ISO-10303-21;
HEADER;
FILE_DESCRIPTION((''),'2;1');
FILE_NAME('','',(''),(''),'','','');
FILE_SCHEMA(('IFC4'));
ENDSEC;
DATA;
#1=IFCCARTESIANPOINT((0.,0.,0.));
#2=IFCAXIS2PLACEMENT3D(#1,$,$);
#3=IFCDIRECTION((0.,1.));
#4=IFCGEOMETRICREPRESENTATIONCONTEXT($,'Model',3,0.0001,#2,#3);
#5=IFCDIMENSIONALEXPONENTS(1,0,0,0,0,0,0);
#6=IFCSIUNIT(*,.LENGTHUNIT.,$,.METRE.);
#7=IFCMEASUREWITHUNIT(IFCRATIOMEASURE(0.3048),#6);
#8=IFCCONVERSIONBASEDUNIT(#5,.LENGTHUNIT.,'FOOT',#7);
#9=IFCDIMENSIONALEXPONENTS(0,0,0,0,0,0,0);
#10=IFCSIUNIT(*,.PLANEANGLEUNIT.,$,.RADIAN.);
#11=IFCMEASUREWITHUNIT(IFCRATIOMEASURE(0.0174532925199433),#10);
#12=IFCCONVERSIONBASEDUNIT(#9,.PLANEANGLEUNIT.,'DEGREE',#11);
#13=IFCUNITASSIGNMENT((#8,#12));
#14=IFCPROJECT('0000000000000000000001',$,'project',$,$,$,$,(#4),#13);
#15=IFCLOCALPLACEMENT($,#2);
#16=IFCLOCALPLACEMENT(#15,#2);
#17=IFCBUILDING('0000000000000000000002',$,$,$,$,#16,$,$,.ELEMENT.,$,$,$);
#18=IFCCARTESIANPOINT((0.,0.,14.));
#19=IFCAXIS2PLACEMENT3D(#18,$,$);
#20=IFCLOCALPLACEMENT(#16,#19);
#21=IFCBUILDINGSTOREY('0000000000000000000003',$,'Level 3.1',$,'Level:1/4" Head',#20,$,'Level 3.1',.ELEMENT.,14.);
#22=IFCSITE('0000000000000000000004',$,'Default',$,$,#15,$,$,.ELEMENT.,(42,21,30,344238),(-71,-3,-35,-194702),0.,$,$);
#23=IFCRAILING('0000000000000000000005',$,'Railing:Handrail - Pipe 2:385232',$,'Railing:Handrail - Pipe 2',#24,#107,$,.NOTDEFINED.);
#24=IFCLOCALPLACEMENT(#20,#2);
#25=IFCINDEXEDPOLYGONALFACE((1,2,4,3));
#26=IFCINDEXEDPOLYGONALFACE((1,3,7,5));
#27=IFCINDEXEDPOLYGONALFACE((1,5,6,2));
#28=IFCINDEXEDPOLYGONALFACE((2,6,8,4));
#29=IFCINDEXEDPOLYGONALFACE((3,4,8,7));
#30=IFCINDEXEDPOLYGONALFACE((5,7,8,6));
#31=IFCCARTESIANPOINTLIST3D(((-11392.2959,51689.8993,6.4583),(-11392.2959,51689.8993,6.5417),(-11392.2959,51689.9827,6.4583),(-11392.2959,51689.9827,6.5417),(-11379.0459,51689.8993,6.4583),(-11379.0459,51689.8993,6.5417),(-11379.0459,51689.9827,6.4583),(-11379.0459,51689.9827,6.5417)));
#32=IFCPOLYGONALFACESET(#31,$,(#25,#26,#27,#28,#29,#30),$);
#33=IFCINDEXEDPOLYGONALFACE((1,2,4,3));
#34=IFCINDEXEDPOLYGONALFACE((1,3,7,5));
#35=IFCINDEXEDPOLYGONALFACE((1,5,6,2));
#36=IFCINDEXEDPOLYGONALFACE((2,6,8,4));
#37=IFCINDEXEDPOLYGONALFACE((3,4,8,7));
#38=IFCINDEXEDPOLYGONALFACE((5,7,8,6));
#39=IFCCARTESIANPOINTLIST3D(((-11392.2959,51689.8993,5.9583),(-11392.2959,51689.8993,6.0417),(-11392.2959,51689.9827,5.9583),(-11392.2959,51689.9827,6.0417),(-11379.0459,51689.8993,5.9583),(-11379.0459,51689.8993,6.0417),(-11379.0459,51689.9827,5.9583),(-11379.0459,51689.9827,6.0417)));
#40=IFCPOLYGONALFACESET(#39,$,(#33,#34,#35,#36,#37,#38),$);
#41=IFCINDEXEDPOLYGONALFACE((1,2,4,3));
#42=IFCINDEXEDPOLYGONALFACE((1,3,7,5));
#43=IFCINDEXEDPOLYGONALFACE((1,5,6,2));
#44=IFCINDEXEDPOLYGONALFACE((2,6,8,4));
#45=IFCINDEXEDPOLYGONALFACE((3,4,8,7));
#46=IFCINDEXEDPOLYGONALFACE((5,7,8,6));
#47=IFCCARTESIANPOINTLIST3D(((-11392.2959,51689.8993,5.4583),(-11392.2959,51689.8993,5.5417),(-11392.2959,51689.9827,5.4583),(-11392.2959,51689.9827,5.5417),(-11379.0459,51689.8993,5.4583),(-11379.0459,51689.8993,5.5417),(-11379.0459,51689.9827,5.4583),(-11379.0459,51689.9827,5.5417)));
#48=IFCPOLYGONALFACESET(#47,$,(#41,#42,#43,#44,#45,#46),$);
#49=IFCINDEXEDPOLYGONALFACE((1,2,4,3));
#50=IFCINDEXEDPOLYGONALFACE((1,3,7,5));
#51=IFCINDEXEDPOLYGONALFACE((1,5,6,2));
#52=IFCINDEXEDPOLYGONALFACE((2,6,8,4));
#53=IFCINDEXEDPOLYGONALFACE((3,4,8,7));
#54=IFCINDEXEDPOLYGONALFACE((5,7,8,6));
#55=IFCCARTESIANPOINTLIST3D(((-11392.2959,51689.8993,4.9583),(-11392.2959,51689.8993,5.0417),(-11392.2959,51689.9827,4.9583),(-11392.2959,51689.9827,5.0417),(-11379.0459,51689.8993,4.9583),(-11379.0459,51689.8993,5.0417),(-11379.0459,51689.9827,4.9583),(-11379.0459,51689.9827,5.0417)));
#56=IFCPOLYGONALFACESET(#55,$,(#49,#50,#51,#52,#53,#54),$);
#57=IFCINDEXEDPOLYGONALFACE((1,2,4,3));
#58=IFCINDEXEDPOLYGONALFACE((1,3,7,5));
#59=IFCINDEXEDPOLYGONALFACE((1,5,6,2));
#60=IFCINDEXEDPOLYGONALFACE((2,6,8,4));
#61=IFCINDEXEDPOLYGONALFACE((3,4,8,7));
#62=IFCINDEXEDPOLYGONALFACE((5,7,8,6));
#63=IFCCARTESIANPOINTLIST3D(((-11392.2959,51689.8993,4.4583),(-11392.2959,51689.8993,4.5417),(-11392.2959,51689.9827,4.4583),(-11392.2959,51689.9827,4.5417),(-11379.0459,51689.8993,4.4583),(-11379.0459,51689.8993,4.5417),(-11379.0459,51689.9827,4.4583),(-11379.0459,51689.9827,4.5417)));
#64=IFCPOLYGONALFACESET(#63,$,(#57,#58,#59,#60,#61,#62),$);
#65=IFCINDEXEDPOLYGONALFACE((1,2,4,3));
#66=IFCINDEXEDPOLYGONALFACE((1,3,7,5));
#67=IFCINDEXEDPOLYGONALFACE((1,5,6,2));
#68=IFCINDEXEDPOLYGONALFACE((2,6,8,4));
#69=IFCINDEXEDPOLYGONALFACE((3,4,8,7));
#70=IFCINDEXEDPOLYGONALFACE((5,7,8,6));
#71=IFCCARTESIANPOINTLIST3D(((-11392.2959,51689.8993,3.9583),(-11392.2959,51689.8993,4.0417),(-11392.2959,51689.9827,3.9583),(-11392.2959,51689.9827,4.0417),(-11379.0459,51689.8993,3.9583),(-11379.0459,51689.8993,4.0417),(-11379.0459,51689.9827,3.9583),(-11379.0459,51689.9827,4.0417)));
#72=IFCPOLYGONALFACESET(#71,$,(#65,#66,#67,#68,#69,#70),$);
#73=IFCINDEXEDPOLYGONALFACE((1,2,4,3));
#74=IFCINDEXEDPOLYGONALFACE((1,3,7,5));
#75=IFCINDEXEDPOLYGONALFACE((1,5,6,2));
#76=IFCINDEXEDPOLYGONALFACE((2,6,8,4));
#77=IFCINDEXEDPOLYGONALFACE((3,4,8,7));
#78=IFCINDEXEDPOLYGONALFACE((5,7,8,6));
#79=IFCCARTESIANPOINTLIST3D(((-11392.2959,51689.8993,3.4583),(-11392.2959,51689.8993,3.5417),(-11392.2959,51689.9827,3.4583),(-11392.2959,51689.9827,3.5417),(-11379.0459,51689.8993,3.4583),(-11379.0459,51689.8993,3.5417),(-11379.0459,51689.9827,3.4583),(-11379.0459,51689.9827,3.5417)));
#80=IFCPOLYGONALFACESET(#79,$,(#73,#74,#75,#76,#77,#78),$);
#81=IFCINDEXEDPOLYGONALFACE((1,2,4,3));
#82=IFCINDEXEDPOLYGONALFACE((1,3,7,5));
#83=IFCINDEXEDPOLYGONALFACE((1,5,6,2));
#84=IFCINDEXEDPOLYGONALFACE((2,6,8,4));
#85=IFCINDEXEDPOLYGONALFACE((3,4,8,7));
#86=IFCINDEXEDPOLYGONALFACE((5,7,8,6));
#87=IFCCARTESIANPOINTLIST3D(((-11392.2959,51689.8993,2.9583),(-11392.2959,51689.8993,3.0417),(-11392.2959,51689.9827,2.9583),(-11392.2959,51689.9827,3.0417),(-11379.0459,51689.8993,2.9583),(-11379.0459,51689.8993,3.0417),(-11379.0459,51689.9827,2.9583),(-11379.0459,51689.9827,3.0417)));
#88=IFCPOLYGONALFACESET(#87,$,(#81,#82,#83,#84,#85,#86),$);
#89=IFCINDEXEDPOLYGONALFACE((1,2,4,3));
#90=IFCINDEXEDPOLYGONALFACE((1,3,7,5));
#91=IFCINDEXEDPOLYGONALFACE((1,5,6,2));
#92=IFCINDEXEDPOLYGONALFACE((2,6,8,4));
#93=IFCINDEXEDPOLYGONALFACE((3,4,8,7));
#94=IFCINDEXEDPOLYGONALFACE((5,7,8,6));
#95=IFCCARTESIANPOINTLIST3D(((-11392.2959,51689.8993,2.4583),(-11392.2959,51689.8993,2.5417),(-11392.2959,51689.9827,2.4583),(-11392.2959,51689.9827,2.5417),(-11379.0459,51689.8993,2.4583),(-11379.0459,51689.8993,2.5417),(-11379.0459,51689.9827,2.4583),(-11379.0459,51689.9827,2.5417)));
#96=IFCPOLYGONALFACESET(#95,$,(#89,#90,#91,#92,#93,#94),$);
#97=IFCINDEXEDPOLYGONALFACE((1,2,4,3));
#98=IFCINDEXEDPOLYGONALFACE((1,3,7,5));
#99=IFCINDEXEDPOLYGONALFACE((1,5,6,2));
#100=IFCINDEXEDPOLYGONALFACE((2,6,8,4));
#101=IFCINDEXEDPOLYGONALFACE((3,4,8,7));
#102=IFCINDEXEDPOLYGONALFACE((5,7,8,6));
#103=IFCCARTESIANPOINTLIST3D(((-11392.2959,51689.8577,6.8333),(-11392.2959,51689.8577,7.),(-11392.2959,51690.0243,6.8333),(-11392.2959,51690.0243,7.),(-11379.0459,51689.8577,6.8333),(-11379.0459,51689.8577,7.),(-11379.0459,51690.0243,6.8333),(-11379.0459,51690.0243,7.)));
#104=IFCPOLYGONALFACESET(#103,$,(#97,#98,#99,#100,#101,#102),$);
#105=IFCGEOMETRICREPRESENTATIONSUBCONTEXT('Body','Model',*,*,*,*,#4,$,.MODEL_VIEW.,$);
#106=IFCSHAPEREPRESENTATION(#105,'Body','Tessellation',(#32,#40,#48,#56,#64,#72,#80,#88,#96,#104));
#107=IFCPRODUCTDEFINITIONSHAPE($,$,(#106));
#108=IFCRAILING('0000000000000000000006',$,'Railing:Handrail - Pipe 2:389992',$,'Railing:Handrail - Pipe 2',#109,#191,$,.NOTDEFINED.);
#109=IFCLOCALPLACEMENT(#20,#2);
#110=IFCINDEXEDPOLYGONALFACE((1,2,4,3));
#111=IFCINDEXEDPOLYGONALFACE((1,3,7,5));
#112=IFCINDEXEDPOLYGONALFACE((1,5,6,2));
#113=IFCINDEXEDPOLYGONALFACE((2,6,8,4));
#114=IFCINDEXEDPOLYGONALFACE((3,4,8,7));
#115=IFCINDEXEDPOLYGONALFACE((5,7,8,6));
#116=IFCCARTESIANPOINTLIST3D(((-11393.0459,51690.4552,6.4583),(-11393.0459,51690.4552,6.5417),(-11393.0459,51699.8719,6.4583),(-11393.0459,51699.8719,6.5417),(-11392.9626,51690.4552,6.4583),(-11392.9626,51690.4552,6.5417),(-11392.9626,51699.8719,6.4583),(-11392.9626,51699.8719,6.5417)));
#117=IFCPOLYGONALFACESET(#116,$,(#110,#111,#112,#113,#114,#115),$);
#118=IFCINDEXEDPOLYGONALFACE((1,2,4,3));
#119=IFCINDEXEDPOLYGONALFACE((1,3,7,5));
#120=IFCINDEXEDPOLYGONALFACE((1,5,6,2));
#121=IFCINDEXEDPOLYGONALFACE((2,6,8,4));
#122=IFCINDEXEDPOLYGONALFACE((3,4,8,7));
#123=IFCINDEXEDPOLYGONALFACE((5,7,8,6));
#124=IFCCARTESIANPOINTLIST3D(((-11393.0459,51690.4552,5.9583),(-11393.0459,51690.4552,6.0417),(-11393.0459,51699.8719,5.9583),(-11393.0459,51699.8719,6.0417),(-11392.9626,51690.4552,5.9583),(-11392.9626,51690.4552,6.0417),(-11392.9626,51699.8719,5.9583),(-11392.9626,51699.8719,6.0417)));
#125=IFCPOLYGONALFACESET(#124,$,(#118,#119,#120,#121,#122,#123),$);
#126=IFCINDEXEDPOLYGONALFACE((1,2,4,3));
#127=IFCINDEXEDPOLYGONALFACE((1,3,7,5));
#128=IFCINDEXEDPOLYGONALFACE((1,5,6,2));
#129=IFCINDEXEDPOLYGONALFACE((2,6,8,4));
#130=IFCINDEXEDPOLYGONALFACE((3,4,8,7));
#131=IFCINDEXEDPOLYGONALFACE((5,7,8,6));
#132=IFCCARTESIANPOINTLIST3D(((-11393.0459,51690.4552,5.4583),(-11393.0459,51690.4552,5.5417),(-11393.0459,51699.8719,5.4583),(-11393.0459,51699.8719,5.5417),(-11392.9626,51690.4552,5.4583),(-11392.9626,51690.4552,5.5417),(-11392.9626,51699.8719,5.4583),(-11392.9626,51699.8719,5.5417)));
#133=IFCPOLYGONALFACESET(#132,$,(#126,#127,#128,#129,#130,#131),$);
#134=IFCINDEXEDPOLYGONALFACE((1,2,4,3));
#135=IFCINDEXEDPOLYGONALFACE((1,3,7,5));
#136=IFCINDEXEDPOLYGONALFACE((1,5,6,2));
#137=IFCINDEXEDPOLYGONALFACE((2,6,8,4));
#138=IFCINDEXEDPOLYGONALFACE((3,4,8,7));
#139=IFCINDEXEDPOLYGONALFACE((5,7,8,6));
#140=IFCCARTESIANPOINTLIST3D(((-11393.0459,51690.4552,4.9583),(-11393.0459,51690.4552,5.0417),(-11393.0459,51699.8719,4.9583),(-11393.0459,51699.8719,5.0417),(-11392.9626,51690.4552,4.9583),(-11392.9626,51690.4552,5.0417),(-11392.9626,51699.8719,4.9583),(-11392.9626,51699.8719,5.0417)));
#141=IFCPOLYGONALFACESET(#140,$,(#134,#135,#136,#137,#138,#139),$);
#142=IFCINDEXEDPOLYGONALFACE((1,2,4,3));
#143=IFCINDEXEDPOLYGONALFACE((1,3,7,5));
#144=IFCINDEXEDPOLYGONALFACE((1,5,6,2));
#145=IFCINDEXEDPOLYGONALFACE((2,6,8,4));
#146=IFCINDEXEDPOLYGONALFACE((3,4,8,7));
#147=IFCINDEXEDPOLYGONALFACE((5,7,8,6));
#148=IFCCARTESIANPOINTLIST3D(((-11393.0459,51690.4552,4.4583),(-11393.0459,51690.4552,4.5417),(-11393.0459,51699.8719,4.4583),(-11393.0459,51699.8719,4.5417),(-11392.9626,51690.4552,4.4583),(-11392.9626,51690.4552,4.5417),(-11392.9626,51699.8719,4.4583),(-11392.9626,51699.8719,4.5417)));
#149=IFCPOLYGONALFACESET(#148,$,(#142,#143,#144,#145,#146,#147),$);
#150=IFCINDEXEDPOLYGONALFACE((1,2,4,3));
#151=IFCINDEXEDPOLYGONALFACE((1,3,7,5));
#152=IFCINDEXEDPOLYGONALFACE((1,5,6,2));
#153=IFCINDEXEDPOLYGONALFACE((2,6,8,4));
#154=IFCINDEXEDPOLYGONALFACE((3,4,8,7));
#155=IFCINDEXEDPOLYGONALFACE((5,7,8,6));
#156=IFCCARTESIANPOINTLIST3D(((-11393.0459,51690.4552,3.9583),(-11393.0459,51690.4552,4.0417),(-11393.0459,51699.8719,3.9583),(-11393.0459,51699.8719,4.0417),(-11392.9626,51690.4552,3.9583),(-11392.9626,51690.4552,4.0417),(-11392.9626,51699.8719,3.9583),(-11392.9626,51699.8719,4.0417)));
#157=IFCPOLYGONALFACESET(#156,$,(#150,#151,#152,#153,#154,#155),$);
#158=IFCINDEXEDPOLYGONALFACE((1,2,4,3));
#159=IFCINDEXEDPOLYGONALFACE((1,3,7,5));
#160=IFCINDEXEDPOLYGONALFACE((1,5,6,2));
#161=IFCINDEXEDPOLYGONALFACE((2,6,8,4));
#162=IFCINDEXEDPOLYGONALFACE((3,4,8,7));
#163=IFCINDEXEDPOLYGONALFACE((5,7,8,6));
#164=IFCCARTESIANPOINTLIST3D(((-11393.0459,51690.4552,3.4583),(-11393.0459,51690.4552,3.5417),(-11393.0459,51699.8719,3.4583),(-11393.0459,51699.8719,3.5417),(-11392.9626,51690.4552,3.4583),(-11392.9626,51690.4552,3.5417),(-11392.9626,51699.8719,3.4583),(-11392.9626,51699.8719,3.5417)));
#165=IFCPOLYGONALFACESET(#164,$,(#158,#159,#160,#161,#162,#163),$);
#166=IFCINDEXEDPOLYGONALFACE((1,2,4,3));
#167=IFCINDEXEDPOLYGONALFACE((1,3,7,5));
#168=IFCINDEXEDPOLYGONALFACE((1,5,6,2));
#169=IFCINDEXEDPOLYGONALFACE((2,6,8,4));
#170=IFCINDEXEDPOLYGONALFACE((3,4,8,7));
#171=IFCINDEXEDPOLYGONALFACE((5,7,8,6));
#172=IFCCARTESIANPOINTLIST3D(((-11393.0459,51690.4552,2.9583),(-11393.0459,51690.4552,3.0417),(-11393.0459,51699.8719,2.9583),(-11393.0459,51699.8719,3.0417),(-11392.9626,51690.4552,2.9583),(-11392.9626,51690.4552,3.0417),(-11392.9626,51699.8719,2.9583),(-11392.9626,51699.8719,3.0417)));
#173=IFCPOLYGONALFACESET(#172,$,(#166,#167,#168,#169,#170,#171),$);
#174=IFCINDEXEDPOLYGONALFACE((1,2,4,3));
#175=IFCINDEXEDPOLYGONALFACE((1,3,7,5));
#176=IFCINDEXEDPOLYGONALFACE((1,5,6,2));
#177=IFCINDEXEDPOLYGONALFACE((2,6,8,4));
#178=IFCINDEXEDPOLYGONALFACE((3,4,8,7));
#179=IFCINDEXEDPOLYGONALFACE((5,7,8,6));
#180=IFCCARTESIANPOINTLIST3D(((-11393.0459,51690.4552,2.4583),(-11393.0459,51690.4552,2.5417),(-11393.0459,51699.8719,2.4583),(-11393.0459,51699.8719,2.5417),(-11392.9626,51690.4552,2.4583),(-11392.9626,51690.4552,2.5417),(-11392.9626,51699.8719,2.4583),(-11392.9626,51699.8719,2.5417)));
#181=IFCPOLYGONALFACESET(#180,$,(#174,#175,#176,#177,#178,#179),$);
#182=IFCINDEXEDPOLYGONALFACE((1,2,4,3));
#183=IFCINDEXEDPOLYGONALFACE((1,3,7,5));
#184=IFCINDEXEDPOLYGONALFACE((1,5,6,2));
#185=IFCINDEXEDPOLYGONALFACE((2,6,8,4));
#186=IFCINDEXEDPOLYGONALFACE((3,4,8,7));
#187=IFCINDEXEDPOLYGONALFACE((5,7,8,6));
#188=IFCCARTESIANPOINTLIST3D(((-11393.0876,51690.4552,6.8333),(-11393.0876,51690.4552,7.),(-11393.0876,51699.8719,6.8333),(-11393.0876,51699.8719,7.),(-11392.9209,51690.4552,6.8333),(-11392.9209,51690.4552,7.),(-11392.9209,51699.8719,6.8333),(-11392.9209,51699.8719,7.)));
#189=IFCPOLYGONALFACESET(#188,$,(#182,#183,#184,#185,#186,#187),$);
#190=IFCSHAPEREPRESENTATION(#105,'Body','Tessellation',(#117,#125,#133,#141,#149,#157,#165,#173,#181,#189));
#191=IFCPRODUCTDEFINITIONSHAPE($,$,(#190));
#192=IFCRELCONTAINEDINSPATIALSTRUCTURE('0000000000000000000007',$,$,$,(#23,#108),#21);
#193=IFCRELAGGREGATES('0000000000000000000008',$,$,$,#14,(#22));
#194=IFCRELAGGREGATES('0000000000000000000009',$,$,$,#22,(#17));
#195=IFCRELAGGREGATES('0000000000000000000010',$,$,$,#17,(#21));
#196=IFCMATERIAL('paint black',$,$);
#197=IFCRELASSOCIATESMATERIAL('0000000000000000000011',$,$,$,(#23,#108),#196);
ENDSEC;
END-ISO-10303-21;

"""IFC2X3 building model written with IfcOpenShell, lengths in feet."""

from ifc_helpers import new_model, entity, si_unit, converted_unit, direction, frame, frame_2d, origin, place, context, subcontext, project, spatial, rectangle, extrude, material, element, save


model = new_model("IFC2X3")

# Units and contexts
model_context = context("Model", 3, precision=0.0001, world=origin(), true_north=direction((0.0, 1.0)))
body_context = subcontext(model_context, "Body", "Model", "MODEL_VIEW")
ifc_project = project(units=[converted_unit("LENGTHUNIT", "FOOT", entity("IfcRatioMeasure", 0.3048), si_unit("LENGTHUNIT", "METRE"), dimensions=[1, 0, 0, 0, 0, 0, 0]), converted_unit("PLANEANGLEUNIT", "DEGREE", entity("IfcRatioMeasure", 0.0174532925199433), si_unit("PLANEANGLEUNIT", "RADIAN"), dimensions=[0, 0, 0, 0, 0, 0, 0])], contexts=[model_context])

# Site, building, storey
site_placement = place(None, origin())
site = spatial("IfcSite", under=ifc_project, at=site_placement, Name="Default", CompositionType="ELEMENT", RefLatitude=(42, 21, 30, 344238), RefLongitude=(-71, -3, -35, -194702), RefElevation=0.0)
building_placement = place(site_placement, origin())
building = spatial("IfcBuilding", under=site, at=building_placement, CompositionType="ELEMENT")
storey_placement = place(building_placement, frame((0.0, 0.0, 14.0)))
storey = spatial("IfcBuildingStorey", under=building, at=storey_placement, Name="Level 3.1", ObjectType="Level:1/4\" Head", LongName="Level 3.1", CompositionType="ELEMENT", Elevation=14.0)

# Railings
ifc_material_1 = material(Name="paint black")
railing_1_placement = place(storey_placement, origin())
element("IfcRailing", 1, at=railing_1_placement, inside=storey, material=ifc_material_1, Name="Railing:Handrail - Pipe 2:385232", ObjectType="Railing:Handrail - Pipe 2", PredefinedType="NOTDEFINED", context=body_context, shape_type="SweptSolid", body=[
    extrude(rectangle(XDim=13.25, YDim=0.0833, at=frame_2d((0.0, 0.0), x_axis=(1.0, 0.0))), frame((-11385.6709, 51689.941, 6.4583), z_axis=(0.0, 0.0, 1.0), x_axis=(-1.0, 0.0, 0.0)), (0.0, 0.0, 1.0), 0.0833),
    extrude(rectangle(XDim=13.25, YDim=0.0833, at=frame_2d((0.0, 0.0), x_axis=(1.0, 0.0))), frame((-11385.6709, 51689.941, 5.9583), z_axis=(0.0, 0.0, 1.0), x_axis=(-1.0, 0.0, 0.0)), (0.0, 0.0, 1.0), 0.0833),
    extrude(rectangle(XDim=13.25, YDim=0.0833, at=frame_2d((0.0, 0.0), x_axis=(1.0, 0.0))), frame((-11385.6709, 51689.941, 5.4583), z_axis=(0.0, 0.0, 1.0), x_axis=(-1.0, 0.0, 0.0)), (0.0, 0.0, 1.0), 0.0833),
    extrude(rectangle(XDim=13.25, YDim=0.0833, at=frame_2d((0.0, 0.0), x_axis=(1.0, 0.0))), frame((-11385.6709, 51689.941, 4.9583), z_axis=(0.0, 0.0, 1.0), x_axis=(-1.0, 0.0, 0.0)), (0.0, 0.0, 1.0), 0.0833),
    extrude(rectangle(XDim=13.25, YDim=0.0833, at=frame_2d((0.0, 0.0), x_axis=(1.0, 0.0))), frame((-11385.6709, 51689.941, 4.4583), z_axis=(0.0, 0.0, 1.0), x_axis=(-1.0, 0.0, 0.0)), (0.0, 0.0, 1.0), 0.0833),
    extrude(rectangle(XDim=13.25, YDim=0.0833, at=frame_2d((0.0, 0.0), x_axis=(1.0, 0.0))), frame((-11385.6709, 51689.941, 3.9583), z_axis=(0.0, 0.0, 1.0), x_axis=(-1.0, 0.0, 0.0)), (0.0, 0.0, 1.0), 0.0833),
    extrude(rectangle(XDim=13.25, YDim=0.0833, at=frame_2d((0.0, 0.0), x_axis=(1.0, 0.0))), frame((-11385.6709, 51689.941, 3.4583), z_axis=(0.0, 0.0, 1.0), x_axis=(-1.0, 0.0, 0.0)), (0.0, 0.0, 1.0), 0.0833),
    extrude(rectangle(XDim=13.25, YDim=0.0833, at=frame_2d((0.0, 0.0), x_axis=(1.0, 0.0))), frame((-11385.6709, 51689.941, 2.9583), z_axis=(0.0, 0.0, 1.0), x_axis=(-1.0, 0.0, 0.0)), (0.0, 0.0, 1.0), 0.0833),
    extrude(rectangle(XDim=13.25, YDim=0.0833, at=frame_2d((0.0, 0.0), x_axis=(1.0, 0.0))), frame((-11385.6709, 51689.941, 2.4583), z_axis=(0.0, 0.0, 1.0), x_axis=(-1.0, 0.0, 0.0)), (0.0, 0.0, 1.0), 0.0833),
    extrude(rectangle(XDim=13.25, YDim=0.1667, at=frame_2d((0.0, 0.0), x_axis=(1.0, 0.0))), frame((-11385.6709, 51689.941, 6.8333), z_axis=(0.0, 0.0, 1.0), x_axis=(-1.0, 0.0, 0.0)), (0.0, 0.0, 1.0), 0.1667),
])
railing_2_placement = place(storey_placement, origin())
element("IfcRailing", 2, at=railing_2_placement, inside=storey, material=ifc_material_1, Name="Railing:Handrail - Pipe 2:389992", ObjectType="Railing:Handrail - Pipe 2", PredefinedType="NOTDEFINED", context=body_context, shape_type="SweptSolid", body=[
    extrude(rectangle(XDim=9.4167, YDim=0.0833, at=frame_2d((0.0, 0.0), x_axis=(1.0, 0.0))), frame((-11393.0042, 51695.1636, 6.4583), z_axis=(0.0, 0.0, 1.0), x_axis=(0.0, 1.0, 0.0)), (0.0, 0.0, 1.0), 0.0833),
    extrude(rectangle(XDim=9.4167, YDim=0.0833, at=frame_2d((0.0, 0.0), x_axis=(1.0, 0.0))), frame((-11393.0042, 51695.1636, 5.9583), z_axis=(0.0, 0.0, 1.0), x_axis=(0.0, 1.0, 0.0)), (0.0, 0.0, 1.0), 0.0833),
    extrude(rectangle(XDim=9.4167, YDim=0.0833, at=frame_2d((0.0, 0.0), x_axis=(1.0, 0.0))), frame((-11393.0042, 51695.1636, 5.4583), z_axis=(0.0, 0.0, 1.0), x_axis=(0.0, 1.0, 0.0)), (0.0, 0.0, 1.0), 0.0833),
    extrude(rectangle(XDim=9.4167, YDim=0.0833, at=frame_2d((0.0, 0.0), x_axis=(1.0, 0.0))), frame((-11393.0042, 51695.1636, 4.9583), z_axis=(0.0, 0.0, 1.0), x_axis=(0.0, 1.0, 0.0)), (0.0, 0.0, 1.0), 0.0833),
    extrude(rectangle(XDim=9.4167, YDim=0.0833, at=frame_2d((0.0, 0.0), x_axis=(1.0, 0.0))), frame((-11393.0042, 51695.1636, 4.4583), z_axis=(0.0, 0.0, 1.0), x_axis=(0.0, 1.0, 0.0)), (0.0, 0.0, 1.0), 0.0833),
    extrude(rectangle(XDim=9.4167, YDim=0.0833, at=frame_2d((0.0, 0.0), x_axis=(1.0, 0.0))), frame((-11393.0042, 51695.1636, 3.9583), z_axis=(0.0, 0.0, 1.0), x_axis=(0.0, 1.0, 0.0)), (0.0, 0.0, 1.0), 0.0833),
    extrude(rectangle(XDim=9.4167, YDim=0.0833, at=frame_2d((0.0, 0.0), x_axis=(1.0, 0.0))), frame((-11393.0042, 51695.1636, 3.4583), z_axis=(0.0, 0.0, 1.0), x_axis=(0.0, 1.0, 0.0)), (0.0, 0.0, 1.0), 0.0833),
    extrude(rectangle(XDim=9.4167, YDim=0.0833, at=frame_2d((0.0, 0.0), x_axis=(1.0, 0.0))), frame((-11393.0042, 51695.1636, 2.9583), z_axis=(0.0, 0.0, 1.0), x_axis=(0.0, 1.0, 0.0)), (0.0, 0.0, 1.0), 0.0833),
    extrude(rectangle(XDim=9.4167, YDim=0.0833, at=frame_2d((0.0, 0.0), x_axis=(1.0, 0.0))), frame((-11393.0042, 51695.1636, 2.4583), z_axis=(0.0, 0.0, 1.0), x_axis=(0.0, 1.0, 0.0)), (0.0, 0.0, 1.0), 0.0833),
    extrude(rectangle(XDim=9.4167, YDim=0.1667, at=frame_2d((0.0, 0.0), x_axis=(1.0, 0.0))), frame((-11393.0042, 51695.1636, 6.8333), z_axis=(0.0, 0.0, 1.0), x_axis=(0.0, 1.0, 0.0)), (0.0, 0.0, 1.0), 0.1667),
])

save(model, "model.ifc")
